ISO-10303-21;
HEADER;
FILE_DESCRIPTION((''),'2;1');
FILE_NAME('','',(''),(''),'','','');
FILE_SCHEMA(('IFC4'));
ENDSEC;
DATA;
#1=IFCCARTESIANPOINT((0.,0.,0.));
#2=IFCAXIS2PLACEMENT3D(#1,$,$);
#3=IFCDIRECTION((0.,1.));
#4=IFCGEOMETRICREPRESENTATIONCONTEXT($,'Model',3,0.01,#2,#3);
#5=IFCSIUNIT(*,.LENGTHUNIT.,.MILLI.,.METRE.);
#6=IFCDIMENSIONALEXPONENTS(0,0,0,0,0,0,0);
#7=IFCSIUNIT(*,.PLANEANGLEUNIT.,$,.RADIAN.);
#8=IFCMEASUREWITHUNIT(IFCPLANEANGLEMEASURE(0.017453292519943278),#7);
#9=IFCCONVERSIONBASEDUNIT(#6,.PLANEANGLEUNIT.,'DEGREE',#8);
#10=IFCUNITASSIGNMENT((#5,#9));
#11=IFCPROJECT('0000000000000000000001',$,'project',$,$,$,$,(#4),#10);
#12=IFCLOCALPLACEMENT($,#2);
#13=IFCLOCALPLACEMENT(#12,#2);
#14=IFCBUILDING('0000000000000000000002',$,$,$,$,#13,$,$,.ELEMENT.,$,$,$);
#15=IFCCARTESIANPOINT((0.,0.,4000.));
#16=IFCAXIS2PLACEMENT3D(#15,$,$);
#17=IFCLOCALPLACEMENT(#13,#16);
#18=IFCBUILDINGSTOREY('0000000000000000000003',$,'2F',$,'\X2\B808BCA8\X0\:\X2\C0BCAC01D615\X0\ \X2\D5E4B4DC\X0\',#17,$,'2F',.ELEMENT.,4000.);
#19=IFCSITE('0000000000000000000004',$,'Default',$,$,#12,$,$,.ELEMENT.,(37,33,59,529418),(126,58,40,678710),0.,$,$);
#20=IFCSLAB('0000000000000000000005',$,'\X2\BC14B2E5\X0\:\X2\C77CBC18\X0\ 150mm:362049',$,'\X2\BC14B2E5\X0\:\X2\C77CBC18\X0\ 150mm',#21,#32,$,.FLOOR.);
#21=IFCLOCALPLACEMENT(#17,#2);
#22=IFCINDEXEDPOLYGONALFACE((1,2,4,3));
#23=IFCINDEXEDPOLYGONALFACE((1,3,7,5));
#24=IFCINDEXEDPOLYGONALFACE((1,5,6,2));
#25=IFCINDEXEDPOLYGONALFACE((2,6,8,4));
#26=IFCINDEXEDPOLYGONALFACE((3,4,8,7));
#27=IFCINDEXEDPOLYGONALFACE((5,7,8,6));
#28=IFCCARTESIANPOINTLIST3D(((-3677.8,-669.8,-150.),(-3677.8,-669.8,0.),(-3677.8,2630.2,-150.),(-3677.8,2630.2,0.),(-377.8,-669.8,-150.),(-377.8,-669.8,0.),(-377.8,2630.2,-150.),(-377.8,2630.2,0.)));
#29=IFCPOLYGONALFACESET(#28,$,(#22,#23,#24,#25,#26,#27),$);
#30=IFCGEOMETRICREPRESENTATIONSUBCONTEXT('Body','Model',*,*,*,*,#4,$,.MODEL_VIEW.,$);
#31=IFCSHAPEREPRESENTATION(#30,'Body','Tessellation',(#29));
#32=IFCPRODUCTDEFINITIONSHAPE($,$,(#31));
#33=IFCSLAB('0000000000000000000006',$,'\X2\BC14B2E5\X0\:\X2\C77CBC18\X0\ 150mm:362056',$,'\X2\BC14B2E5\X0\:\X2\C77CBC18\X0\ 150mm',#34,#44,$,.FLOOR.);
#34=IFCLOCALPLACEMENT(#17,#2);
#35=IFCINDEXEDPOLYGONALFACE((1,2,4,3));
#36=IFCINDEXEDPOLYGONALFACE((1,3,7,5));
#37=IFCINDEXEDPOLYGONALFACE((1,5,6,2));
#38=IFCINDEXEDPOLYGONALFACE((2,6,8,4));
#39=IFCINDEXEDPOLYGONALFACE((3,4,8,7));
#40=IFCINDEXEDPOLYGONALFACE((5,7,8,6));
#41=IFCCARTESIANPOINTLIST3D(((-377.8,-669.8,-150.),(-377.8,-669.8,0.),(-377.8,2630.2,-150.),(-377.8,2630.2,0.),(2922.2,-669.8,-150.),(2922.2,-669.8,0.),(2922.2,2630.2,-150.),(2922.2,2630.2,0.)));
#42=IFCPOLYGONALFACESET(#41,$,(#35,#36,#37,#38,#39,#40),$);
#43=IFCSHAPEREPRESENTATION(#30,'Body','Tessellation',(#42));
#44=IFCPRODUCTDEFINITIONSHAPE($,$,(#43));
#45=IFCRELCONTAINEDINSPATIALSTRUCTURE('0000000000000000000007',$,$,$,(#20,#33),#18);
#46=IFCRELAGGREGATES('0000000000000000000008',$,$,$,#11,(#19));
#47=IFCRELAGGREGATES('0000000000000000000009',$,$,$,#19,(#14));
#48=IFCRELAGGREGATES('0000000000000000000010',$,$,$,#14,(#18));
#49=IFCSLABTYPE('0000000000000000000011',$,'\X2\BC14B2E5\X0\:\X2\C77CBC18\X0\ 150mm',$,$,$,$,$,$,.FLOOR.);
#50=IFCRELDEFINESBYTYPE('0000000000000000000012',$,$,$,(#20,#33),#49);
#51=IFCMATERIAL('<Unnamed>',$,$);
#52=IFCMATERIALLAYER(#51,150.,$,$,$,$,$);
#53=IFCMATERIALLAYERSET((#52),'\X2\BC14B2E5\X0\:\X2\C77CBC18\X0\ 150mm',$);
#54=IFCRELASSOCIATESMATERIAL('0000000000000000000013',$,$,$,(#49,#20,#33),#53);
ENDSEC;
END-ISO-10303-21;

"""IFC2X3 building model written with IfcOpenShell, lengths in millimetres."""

from ifc_helpers import new_model, entity, si_unit, converted_unit, direction, frame, origin, origin_2d_with_axis, place, context, subcontext, project, spatial, rectangle, extrude, material, layer, layer_set, layer_usage, type_object, element, save


model = new_model("IFC2X3")

# Units and contexts
model_context = context("Model", 3, precision=0.01, world=origin(), true_north=direction((0.0, 1.0)))
body_context = subcontext(model_context, "Body", "Model", "MODEL_VIEW")
ifc_project = project(units=[si_unit("LENGTHUNIT", "METRE", prefix="MILLI"), converted_unit("PLANEANGLEUNIT", "DEGREE", entity("IfcPlaneAngleMeasure", 0.017453292519943278), si_unit("PLANEANGLEUNIT", "RADIAN"), dimensions=[0, 0, 0, 0, 0, 0, 0])], contexts=[model_context])

# Site, building, storey
site_placement = place(None, origin())
site = spatial("IfcSite", under=ifc_project, at=site_placement, Name="Default", CompositionType="ELEMENT", RefLatitude=(37, 33, 59, 529418), RefLongitude=(126, 58, 40, 678710), RefElevation=0.0)
building_placement = place(site_placement, origin())
building = spatial("IfcBuilding", under=site, at=building_placement, CompositionType="ELEMENT")
storey_placement = place(building_placement, frame((0.0, 0.0, 4000.0)))
storey = spatial("IfcBuildingStorey", under=building, at=storey_placement, Name="2F", ObjectType="레벨:삼각형 헤드", LongName="2F", CompositionType="ELEMENT", Elevation=4000.0)

# Slabs
ifc_material = material(Name="<Unnamed>")
ifc_layer = layer(ifc_material, 150.0)
ifc_layer_set = layer_set([ifc_layer], Name="바닥:일반 150mm")
ifc_layer_usage = layer_usage(ifc_layer_set, "AXIS3", "POSITIVE", 0.0)
slab_type = type_object("IfcSlabType", Name="바닥:일반 150mm", PredefinedType="FLOOR", material=ifc_layer_set)
slab_1_placement = place(storey_placement, origin())
element("IfcSlab", 1, at=slab_1_placement, inside=storey, type_object=slab_type, material=ifc_layer_usage, Name="바닥:일반 150mm:362049", ObjectType="바닥:일반 150mm", PredefinedType="FLOOR", context=body_context, shape_type="SweptSolid", body=[
    extrude(rectangle(XDim=3300.0, YDim=3300.0, at=origin_2d_with_axis()), frame((-2027.8, 980.2, 0.0), z_axis=(0.0, 0.0, -1.0), x_axis=(0.0, 1.0, 0.0)), (0.0, 0.0, 1.0), 150.0),
])
slab_2_placement = place(storey_placement, origin())
element("IfcSlab", 2, at=slab_2_placement, inside=storey, type_object=slab_type, material=ifc_layer_usage, Name="바닥:일반 150mm:362056", ObjectType="바닥:일반 150mm", PredefinedType="FLOOR", context=body_context, shape_type="SweptSolid", body=[
    extrude(rectangle(XDim=3300.0, YDim=3300.0, at=origin_2d_with_axis()), frame((1272.2, 980.2, 0.0), z_axis=(0.0, 0.0, -1.0), x_axis=(0.0, 1.0, 0.0)), (0.0, 0.0, 1.0), 150.0),
])

save(model, "model.ifc")
